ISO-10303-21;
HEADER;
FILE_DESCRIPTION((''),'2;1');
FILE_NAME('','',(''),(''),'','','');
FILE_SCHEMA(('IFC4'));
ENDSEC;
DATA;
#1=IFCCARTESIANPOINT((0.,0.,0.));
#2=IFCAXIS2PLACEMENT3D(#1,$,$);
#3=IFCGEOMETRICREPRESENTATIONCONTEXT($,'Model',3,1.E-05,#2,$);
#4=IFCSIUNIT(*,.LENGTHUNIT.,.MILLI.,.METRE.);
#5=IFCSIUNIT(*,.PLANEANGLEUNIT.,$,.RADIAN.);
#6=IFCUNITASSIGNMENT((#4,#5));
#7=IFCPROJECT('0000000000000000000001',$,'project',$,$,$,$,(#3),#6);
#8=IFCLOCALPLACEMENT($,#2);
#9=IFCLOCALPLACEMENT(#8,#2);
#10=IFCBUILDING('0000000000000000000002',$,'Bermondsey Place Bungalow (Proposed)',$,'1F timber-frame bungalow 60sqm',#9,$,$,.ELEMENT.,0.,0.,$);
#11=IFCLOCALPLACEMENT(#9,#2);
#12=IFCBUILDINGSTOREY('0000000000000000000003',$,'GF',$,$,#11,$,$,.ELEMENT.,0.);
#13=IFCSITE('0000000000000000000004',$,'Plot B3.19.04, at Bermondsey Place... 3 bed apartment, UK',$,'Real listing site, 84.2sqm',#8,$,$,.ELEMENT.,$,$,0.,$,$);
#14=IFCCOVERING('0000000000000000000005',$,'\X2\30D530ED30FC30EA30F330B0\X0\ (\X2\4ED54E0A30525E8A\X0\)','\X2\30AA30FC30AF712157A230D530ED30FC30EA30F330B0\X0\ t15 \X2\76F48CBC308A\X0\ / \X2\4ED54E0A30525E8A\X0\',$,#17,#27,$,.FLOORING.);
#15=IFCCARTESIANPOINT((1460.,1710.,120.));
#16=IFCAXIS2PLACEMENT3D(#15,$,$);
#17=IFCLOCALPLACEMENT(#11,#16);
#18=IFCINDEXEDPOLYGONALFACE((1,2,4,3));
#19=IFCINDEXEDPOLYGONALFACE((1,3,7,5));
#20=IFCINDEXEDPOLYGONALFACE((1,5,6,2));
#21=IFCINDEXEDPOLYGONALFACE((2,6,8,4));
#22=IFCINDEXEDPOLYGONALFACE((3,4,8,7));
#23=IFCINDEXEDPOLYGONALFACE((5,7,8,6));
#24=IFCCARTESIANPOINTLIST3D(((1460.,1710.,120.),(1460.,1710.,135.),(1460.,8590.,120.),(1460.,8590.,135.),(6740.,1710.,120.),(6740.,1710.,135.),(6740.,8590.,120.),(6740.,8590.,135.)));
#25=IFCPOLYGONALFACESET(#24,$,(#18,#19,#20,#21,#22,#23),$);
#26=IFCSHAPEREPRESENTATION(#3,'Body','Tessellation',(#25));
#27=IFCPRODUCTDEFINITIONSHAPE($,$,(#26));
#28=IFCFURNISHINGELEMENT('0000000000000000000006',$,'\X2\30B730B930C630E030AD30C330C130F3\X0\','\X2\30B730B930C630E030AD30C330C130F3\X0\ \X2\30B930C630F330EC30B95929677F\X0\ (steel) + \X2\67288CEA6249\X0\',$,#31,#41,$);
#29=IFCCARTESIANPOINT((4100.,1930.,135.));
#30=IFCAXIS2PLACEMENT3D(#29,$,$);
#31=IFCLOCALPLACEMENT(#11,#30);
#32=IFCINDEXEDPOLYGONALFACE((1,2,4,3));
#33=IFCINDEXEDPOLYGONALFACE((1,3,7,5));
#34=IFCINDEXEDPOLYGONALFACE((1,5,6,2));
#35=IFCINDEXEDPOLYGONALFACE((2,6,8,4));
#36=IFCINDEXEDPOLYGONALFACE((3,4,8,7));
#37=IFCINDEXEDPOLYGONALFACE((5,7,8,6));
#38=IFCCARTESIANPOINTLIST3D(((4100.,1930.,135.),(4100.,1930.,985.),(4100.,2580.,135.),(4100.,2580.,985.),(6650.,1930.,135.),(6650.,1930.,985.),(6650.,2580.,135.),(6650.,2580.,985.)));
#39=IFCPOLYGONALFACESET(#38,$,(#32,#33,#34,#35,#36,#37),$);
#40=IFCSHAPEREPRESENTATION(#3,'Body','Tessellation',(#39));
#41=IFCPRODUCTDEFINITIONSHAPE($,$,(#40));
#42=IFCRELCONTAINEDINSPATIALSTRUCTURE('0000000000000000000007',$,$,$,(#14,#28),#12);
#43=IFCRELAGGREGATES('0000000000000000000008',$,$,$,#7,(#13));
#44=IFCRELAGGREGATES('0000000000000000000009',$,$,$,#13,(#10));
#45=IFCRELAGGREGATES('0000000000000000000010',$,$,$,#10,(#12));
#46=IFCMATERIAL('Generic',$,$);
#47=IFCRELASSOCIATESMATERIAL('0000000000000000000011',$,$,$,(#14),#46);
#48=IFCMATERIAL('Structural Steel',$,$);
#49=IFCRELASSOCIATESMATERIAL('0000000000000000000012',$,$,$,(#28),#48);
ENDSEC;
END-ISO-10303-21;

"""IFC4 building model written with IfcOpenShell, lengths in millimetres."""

from ifc_helpers import new_model, si_unit, frame, frame_2d, origin, place, context, project, spatial, rectangle, extrude, material, element, save


model = new_model("IFC4")

# Units and contexts
model_context = context("Model", 3, precision=1e-05, world=origin())
ifc_project = project(units=[si_unit("LENGTHUNIT", "METRE", prefix="MILLI"), si_unit("PLANEANGLEUNIT", "RADIAN")], contexts=[model_context])

# Site, building, storey
site_placement = place(None, origin())
site = spatial("IfcSite", under=ifc_project, at=site_placement, Name="Plot B3.19.04, at Bermondsey Place... 3 bed apartment, UK", ObjectType="Real listing site, 84.2sqm", CompositionType="ELEMENT", RefElevation=0.0)
building_placement = place(site_placement, origin())
building = spatial("IfcBuilding", under=site, at=building_placement, Name="Bermondsey Place Bungalow (Proposed)", ObjectType="1F timber-frame bungalow 60sqm", CompositionType="ELEMENT", ElevationOfRefHeight=0.0, ElevationOfTerrain=0.0)
storey_placement = place(building_placement, origin())
storey = spatial("IfcBuildingStorey", under=building, at=storey_placement, Name="GF", CompositionType="ELEMENT", Elevation=0.0)

# Shared definitions
ifc_material_1 = material(Name="Generic")

# Covering
covering_placement = place(storey_placement, frame((1460.0, 1710.0, 120.0)))
element("IfcCovering", 1, at=covering_placement, inside=storey, material=ifc_material_1, Name="フローリング (仕上げ床)", Description="オーク無垢フローリング t15 直貼り / 仕上げ床", PredefinedType="FLOORING", context=model_context, shape_type="SweptSolid", body=[
    extrude(rectangle(XDim=5280.0, YDim=6880.0, at=frame_2d((2640.0, 3440.0))), frame((1460.0, 1710.0, 120.0)), (0.0, 0.0, 1.0), 15.0),
])

# Furnishing element
ifc_material_2 = material(Name="Structural Steel")
furnishing_placement = place(storey_placement, frame((4100.0, 1930.0, 135.0)))
element("IfcFurnishingElement", 2, at=furnishing_placement, inside=storey, material=ifc_material_2, Name="システムキッチン", Description="システムキッチン ステンレス天板 (steel) + 木質扉", context=model_context, shape_type="SweptSolid", body=[
    extrude(rectangle(XDim=2550.0, YDim=650.0, at=frame_2d((1275.0, 325.0))), frame((4100.0, 1930.0, 135.0)), (0.0, 0.0, 1.0), 850.0),
])

save(model, "model.ifc")
